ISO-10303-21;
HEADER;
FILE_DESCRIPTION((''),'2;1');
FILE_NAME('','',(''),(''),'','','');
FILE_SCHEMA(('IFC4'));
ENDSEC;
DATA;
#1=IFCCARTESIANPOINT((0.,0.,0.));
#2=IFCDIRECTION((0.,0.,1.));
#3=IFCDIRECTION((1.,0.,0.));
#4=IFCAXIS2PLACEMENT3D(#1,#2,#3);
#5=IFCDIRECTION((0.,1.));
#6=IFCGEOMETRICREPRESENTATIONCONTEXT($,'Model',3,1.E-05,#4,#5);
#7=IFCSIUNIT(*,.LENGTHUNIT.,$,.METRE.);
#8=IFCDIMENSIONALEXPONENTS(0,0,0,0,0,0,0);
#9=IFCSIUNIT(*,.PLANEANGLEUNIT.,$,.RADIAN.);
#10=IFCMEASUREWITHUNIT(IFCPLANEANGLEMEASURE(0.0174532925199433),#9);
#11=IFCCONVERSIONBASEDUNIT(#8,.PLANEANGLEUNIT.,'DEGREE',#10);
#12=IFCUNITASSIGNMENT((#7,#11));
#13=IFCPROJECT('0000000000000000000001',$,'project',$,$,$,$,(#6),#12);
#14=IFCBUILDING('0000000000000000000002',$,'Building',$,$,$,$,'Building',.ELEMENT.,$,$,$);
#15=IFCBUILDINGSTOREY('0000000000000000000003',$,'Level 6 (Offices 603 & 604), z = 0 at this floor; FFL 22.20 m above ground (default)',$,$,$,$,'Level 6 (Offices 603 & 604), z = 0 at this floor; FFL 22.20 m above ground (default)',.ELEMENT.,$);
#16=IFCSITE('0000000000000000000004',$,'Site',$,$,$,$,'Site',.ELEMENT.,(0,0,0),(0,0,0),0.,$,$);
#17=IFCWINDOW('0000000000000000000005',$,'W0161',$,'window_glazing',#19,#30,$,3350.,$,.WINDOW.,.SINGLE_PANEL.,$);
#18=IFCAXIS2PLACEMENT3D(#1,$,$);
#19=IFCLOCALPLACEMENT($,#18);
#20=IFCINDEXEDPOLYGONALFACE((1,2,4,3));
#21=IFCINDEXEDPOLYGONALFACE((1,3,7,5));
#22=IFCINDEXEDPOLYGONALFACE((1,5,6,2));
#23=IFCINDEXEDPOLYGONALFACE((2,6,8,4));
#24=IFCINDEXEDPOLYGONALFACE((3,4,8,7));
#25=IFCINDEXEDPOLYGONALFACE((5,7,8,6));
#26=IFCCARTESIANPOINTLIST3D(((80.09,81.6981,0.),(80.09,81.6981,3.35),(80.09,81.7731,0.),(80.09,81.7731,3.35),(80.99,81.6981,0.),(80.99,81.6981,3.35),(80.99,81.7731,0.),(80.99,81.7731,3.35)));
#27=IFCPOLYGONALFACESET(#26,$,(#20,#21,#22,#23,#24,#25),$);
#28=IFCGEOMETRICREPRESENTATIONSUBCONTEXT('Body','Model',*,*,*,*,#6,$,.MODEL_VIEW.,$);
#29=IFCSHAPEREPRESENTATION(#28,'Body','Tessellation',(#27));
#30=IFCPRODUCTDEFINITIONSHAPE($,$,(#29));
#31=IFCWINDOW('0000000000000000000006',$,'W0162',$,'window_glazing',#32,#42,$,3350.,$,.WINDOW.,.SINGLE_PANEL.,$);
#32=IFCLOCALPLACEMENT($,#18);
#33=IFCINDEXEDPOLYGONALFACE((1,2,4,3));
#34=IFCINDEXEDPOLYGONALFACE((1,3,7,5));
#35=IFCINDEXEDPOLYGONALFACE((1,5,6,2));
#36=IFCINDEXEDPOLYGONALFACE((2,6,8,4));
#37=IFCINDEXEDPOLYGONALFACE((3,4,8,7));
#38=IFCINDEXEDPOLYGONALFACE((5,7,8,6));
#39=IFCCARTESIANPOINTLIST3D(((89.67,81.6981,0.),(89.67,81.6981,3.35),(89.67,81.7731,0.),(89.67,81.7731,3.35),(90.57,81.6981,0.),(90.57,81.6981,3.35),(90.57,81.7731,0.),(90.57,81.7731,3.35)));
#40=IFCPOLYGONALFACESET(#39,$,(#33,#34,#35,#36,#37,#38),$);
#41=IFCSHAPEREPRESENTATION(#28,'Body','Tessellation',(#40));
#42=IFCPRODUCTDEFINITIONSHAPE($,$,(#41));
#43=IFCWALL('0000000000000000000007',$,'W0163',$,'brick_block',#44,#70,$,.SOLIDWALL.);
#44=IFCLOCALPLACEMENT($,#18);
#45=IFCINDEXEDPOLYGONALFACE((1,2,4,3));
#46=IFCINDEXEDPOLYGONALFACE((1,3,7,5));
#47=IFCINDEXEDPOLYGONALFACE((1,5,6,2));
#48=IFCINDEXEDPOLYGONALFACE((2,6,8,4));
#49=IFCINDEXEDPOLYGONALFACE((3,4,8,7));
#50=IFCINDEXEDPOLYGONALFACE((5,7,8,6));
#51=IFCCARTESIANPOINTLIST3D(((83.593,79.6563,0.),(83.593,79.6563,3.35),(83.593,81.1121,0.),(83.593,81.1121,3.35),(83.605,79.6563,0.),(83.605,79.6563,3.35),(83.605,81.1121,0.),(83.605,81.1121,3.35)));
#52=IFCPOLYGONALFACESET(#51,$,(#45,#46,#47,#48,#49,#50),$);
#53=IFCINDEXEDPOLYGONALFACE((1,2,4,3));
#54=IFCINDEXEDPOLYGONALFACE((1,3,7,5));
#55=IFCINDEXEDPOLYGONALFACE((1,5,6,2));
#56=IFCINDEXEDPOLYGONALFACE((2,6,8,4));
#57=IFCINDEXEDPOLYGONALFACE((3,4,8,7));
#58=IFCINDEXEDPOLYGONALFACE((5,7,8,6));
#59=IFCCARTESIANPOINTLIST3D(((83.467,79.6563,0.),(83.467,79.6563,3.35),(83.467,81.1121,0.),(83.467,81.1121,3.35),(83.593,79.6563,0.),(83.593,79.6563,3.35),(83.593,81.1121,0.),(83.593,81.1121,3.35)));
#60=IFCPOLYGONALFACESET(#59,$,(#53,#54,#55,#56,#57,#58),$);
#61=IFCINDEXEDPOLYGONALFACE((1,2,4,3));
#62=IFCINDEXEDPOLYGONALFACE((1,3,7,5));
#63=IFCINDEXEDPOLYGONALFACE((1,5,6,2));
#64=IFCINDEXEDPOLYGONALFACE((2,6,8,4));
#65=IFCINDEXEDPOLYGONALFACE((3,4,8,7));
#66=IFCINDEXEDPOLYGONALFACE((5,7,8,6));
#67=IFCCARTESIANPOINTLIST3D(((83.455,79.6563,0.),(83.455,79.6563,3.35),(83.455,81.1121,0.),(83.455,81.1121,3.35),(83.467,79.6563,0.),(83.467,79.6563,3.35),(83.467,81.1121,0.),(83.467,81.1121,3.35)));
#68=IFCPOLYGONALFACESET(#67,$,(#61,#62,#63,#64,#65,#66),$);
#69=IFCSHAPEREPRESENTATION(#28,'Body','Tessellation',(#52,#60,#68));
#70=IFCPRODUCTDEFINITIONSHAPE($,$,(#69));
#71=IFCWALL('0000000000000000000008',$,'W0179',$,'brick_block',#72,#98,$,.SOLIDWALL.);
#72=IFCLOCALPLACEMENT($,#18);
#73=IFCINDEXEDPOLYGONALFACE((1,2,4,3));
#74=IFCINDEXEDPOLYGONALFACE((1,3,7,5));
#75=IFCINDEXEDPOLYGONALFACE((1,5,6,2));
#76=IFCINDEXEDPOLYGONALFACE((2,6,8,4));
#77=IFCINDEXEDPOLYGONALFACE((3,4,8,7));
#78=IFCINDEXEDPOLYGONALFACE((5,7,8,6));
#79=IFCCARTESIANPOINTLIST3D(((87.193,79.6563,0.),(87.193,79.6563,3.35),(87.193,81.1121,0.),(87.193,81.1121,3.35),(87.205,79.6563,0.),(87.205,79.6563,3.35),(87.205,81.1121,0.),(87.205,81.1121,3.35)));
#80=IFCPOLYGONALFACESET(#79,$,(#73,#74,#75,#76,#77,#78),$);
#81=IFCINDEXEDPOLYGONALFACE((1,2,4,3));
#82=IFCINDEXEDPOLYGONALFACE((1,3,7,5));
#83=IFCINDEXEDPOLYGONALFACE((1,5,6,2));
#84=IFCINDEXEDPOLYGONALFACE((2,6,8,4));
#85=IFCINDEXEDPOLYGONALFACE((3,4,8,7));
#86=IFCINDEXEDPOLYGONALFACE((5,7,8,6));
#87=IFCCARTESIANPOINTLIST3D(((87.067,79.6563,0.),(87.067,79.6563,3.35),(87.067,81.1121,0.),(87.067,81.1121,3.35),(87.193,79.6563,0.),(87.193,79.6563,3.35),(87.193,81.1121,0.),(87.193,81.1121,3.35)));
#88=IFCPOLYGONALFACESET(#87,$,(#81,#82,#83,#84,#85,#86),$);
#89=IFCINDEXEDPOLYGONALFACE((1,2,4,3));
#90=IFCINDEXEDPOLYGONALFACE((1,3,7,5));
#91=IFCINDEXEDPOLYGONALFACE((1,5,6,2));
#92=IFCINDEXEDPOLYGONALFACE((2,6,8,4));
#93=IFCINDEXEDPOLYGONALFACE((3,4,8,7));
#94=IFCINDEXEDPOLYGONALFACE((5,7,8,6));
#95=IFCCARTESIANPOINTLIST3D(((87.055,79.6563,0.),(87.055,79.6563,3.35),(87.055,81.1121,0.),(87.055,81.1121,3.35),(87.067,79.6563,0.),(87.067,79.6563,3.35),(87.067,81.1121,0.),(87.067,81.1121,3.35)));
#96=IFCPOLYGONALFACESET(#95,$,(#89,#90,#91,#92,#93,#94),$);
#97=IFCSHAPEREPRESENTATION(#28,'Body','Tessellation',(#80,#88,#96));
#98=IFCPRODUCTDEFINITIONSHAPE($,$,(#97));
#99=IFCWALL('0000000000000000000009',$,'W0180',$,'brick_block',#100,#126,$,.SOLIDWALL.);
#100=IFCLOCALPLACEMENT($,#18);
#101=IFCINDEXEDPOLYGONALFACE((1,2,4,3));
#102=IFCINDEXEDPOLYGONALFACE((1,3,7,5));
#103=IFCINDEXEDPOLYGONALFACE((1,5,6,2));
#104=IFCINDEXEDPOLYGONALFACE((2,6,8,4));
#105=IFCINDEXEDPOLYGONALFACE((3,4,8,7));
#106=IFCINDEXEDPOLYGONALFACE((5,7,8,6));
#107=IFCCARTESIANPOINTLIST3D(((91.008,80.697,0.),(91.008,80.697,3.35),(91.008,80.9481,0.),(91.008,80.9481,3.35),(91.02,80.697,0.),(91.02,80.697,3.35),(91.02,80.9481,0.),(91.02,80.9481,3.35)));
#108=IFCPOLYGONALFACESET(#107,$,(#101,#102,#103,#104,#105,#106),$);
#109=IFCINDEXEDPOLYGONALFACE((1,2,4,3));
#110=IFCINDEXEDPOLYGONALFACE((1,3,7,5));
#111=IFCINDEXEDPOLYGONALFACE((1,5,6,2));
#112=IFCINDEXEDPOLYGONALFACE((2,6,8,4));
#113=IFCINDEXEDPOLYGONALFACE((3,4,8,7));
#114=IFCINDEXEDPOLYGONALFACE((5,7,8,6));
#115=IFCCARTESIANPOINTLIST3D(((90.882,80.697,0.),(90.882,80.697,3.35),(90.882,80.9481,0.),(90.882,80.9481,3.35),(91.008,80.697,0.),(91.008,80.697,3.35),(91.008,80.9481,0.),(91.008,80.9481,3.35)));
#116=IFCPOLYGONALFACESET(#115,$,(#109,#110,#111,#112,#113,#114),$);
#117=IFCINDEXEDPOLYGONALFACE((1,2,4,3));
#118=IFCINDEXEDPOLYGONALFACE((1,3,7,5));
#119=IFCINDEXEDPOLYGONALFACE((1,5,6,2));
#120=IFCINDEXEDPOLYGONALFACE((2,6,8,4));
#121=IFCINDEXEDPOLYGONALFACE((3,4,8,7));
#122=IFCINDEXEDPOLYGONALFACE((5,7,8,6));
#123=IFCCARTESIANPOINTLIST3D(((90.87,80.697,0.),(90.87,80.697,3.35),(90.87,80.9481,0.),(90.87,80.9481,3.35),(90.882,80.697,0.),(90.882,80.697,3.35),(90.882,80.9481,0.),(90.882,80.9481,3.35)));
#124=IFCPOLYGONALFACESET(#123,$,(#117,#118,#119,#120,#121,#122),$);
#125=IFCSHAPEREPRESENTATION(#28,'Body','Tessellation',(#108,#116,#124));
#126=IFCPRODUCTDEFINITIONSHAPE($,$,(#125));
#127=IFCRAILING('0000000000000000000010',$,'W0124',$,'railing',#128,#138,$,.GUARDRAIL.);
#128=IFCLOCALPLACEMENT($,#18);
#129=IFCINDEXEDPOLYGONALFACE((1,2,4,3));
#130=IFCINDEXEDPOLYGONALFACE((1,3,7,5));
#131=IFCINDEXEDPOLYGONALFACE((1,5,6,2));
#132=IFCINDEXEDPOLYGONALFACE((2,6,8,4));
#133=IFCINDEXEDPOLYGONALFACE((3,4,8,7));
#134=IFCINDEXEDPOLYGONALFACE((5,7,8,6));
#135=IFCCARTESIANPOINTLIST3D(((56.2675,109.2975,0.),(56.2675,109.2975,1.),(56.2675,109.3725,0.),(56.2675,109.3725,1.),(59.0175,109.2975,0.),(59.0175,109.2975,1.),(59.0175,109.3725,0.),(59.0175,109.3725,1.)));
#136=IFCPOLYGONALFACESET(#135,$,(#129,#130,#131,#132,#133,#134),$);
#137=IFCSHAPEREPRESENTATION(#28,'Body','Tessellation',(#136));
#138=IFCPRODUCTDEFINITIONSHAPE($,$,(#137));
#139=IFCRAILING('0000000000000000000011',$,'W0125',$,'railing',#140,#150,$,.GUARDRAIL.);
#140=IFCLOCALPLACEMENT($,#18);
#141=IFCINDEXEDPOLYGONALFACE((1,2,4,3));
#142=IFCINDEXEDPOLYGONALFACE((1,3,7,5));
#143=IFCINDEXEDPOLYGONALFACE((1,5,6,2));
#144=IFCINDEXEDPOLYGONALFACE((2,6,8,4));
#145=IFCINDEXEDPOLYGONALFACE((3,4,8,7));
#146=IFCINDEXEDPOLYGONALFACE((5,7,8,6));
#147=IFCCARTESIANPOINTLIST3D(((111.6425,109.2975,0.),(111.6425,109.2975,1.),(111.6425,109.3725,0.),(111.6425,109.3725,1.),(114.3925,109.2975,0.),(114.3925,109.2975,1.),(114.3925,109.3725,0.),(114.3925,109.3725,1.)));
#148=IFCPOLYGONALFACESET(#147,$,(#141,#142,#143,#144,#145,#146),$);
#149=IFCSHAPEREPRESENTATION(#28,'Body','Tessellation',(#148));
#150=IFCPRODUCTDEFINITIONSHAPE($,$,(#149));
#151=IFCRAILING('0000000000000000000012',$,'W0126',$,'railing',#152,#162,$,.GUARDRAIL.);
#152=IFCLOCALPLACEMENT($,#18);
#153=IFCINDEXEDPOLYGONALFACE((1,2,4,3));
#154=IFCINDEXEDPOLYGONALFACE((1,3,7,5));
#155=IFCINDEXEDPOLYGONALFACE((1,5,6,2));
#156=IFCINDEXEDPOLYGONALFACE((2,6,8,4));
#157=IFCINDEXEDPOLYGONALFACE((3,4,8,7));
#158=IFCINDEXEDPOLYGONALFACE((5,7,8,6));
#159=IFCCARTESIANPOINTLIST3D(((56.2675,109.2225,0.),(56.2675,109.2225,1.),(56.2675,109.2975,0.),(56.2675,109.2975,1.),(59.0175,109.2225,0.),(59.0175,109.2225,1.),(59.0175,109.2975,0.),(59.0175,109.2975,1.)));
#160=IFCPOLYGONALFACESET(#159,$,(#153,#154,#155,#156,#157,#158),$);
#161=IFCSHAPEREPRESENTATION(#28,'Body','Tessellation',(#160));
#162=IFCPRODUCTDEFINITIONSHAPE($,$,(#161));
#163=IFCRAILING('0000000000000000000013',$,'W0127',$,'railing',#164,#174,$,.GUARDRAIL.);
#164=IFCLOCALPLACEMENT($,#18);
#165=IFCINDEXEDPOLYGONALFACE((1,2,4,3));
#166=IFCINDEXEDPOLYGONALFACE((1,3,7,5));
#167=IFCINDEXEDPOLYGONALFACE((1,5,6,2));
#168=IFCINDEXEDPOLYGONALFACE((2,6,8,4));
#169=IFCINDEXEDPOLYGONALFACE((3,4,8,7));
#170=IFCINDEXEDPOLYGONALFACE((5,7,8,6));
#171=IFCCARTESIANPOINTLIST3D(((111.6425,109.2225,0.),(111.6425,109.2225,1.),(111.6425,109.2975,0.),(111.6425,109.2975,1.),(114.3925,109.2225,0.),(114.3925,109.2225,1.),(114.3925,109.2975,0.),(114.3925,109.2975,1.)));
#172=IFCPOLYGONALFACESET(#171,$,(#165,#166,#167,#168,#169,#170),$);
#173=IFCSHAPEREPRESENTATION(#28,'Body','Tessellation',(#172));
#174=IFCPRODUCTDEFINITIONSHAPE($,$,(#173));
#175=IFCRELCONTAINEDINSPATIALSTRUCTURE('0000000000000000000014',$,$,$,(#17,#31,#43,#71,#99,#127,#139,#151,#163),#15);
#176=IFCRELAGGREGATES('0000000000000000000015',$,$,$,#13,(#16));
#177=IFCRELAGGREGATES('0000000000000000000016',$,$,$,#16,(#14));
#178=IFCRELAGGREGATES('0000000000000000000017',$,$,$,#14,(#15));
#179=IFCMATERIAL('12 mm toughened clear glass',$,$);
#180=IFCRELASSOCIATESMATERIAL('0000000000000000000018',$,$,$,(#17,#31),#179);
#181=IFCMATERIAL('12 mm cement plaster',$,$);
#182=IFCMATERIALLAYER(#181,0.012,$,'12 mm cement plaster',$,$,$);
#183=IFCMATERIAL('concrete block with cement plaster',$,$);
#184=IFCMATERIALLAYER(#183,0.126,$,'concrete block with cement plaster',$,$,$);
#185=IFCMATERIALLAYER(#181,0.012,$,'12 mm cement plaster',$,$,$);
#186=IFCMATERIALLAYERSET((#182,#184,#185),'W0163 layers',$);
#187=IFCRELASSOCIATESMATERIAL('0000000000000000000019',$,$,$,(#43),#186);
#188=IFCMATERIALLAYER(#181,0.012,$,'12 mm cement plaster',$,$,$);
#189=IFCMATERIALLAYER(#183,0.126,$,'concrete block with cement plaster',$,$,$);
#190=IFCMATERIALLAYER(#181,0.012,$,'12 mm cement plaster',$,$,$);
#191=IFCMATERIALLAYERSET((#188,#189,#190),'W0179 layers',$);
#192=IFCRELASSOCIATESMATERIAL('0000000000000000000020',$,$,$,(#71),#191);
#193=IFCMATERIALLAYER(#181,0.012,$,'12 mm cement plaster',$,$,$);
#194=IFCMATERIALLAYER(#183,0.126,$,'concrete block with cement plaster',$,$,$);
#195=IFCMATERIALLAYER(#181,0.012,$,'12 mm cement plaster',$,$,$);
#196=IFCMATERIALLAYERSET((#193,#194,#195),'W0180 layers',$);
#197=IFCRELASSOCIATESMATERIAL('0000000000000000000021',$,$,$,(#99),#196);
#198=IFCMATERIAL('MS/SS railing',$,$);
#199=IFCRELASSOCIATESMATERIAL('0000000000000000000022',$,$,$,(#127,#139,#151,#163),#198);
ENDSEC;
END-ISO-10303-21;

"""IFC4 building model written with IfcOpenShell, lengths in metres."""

from ifc_helpers import new_model, entity, si_unit, converted_unit, direction, frame, frame_2d, origin_with_axes, place, context, subcontext, project, spatial, rectangle, extrude, material, layer, layer_set, layer_usage, element, save


model = new_model("IFC4")

# Units and contexts
model_context = context("Model", 3, precision=1e-05, world=origin_with_axes(), true_north=direction((0.0, 1.0)))
body_context = subcontext(model_context, "Body", "Model", "MODEL_VIEW")
ifc_project = project(units=[si_unit("LENGTHUNIT", "METRE"), converted_unit("PLANEANGLEUNIT", "DEGREE", entity("IfcPlaneAngleMeasure", 0.0174532925199433), si_unit("PLANEANGLEUNIT", "RADIAN"), dimensions=[0, 0, 0, 0, 0, 0, 0])], contexts=[model_context])

# Site, building, storey
site = spatial("IfcSite", under=ifc_project, Name="Site", LongName="Site", CompositionType="ELEMENT", RefLatitude=(0, 0, 0), RefLongitude=(0, 0, 0), RefElevation=0.0)
building = spatial("IfcBuilding", under=site, Name="Building", LongName="Building", CompositionType="ELEMENT")
storey = spatial("IfcBuildingStorey", under=building, Name="Level 6 (Offices 603 & 604), z = 0 at this floor; FFL 22.20 m above ground (default)", LongName="Level 6 (Offices 603 & 604), z = 0 at this floor; FFL 22.20 m above ground (default)", CompositionType="ELEMENT")

# Shared definitions
ifc_material_1 = material(Name="12 mm cement plaster")
ifc_material_2 = material(Name="concrete block with cement plaster")
placement = place(None, origin_with_axes())

# Shared definitions
ifc_material_3 = material(Name="12 mm toughened clear glass")

# Windows
element("IfcWindow", 1, at=placement, inside=storey, material=ifc_material_3, Name="W0161", ObjectType="window_glazing", OverallHeight=3350.0, PartitioningType="SINGLE_PANEL", PredefinedType="WINDOW", context=body_context, shape_type="SweptSolid", body=[
    extrude(rectangle(XDim=0.9, YDim=0.075, at=frame_2d((0.0, 0.0), x_axis=(1.0, 0.0))), frame((80.54, 81.7356, 0.0), z_axis=(0.0, 0.0, 1.0), x_axis=(1.0, 0.0, 0.0)), (0.0, 0.0, 1.0), 3.35),
])
element("IfcWindow", 2, at=placement, inside=storey, material=ifc_material_3, Name="W0162", ObjectType="window_glazing", OverallHeight=3350.0, PartitioningType="SINGLE_PANEL", PredefinedType="WINDOW", context=body_context, shape_type="SweptSolid", body=[
    extrude(rectangle(XDim=0.9, YDim=0.075, at=frame_2d((0.0, 0.0), x_axis=(1.0, 0.0))), frame((90.12, 81.7356, 0.0), z_axis=(0.0, 0.0, 1.0), x_axis=(1.0, 0.0, 0.0)), (0.0, 0.0, 1.0), 3.35),
])

# Walls
ifc_layer_1 = layer(ifc_material_1, 0.012, Name="12 mm cement plaster")
ifc_layer_2 = layer(ifc_material_2, 0.126, Name="concrete block with cement plaster")
ifc_layer_3 = layer(ifc_material_1, 0.012, Name="12 mm cement plaster")
ifc_layer_set_1 = layer_set([ifc_layer_1, ifc_layer_2, ifc_layer_3], Name="W0163 layers")
ifc_layer_usage_1 = layer_usage(ifc_layer_set_1, "AXIS2", "POSITIVE", -0.075)
element("IfcWall", 3, at=placement, inside=storey, material=ifc_layer_usage_1, Name="W0163", ObjectType="brick_block", PredefinedType="SOLIDWALL", context=body_context, shape_type="SweptSolid", body=[
    extrude(rectangle(XDim=1.4558, YDim=0.012, at=frame_2d((0.0, 0.0), x_axis=(0.0, 1.0))), frame((83.599, 80.3842, 0.0), z_axis=(0.0, 0.0, 1.0), x_axis=(1.0, 0.0, 0.0)), (0.0, 0.0, 1.0), 3.35),
    extrude(rectangle(XDim=1.4558, YDim=0.126, at=frame_2d((-0.069, 0.0), x_axis=(0.0, 1.0))), frame((83.599, 80.3842, 0.0), z_axis=(0.0, 0.0, 1.0), x_axis=(1.0, 0.0, 0.0)), (0.0, 0.0, 1.0), 3.35),
    extrude(rectangle(XDim=1.4558, YDim=0.012, at=frame_2d((-0.138, 0.0), x_axis=(0.0, 1.0))), frame((83.599, 80.3842, 0.0), z_axis=(0.0, 0.0, 1.0), x_axis=(1.0, 0.0, 0.0)), (0.0, 0.0, 1.0), 3.35),
])
ifc_layer_4 = layer(ifc_material_1, 0.012, Name="12 mm cement plaster")
ifc_layer_5 = layer(ifc_material_2, 0.126, Name="concrete block with cement plaster")
ifc_layer_6 = layer(ifc_material_1, 0.012, Name="12 mm cement plaster")
ifc_layer_set_2 = layer_set([ifc_layer_4, ifc_layer_5, ifc_layer_6], Name="W0179 layers")
ifc_layer_usage_2 = layer_usage(ifc_layer_set_2, "AXIS2", "POSITIVE", -0.075)
element("IfcWall", 4, at=placement, inside=storey, material=ifc_layer_usage_2, Name="W0179", ObjectType="brick_block", PredefinedType="SOLIDWALL", context=body_context, shape_type="SweptSolid", body=[
    extrude(rectangle(XDim=1.4558, YDim=0.012, at=frame_2d((0.0, 0.0), x_axis=(0.0, 1.0))), frame((87.199, 80.3842, 0.0), z_axis=(0.0, 0.0, 1.0), x_axis=(1.0, 0.0, 0.0)), (0.0, 0.0, 1.0), 3.35),
    extrude(rectangle(XDim=1.4558, YDim=0.126, at=frame_2d((-0.069, 0.0), x_axis=(0.0, 1.0))), frame((87.199, 80.3842, 0.0), z_axis=(0.0, 0.0, 1.0), x_axis=(1.0, 0.0, 0.0)), (0.0, 0.0, 1.0), 3.35),
    extrude(rectangle(XDim=1.4558, YDim=0.012, at=frame_2d((-0.138, 0.0), x_axis=(0.0, 1.0))), frame((87.199, 80.3842, 0.0), z_axis=(0.0, 0.0, 1.0), x_axis=(1.0, 0.0, 0.0)), (0.0, 0.0, 1.0), 3.35),
])
ifc_layer_7 = layer(ifc_material_1, 0.012, Name="12 mm cement plaster")
ifc_layer_8 = layer(ifc_material_2, 0.126, Name="concrete block with cement plaster")
ifc_layer_9 = layer(ifc_material_1, 0.012, Name="12 mm cement plaster")
ifc_layer_set_3 = layer_set([ifc_layer_7, ifc_layer_8, ifc_layer_9], Name="W0180 layers")
ifc_layer_usage_3 = layer_usage(ifc_layer_set_3, "AXIS2", "POSITIVE", -0.075)
element("IfcWall", 5, at=placement, inside=storey, material=ifc_layer_usage_3, Name="W0180", ObjectType="brick_block", PredefinedType="SOLIDWALL", context=body_context, shape_type="SweptSolid", body=[
    extrude(rectangle(XDim=0.2511, YDim=0.012, at=frame_2d((0.0, 0.0), x_axis=(0.0, 1.0))), frame((91.014, 80.8226, 0.0), z_axis=(0.0, 0.0, 1.0), x_axis=(1.0, 0.0, 0.0)), (0.0, 0.0, 1.0), 3.35),
    extrude(rectangle(XDim=0.2511, YDim=0.126, at=frame_2d((-0.069, 0.0), x_axis=(0.0, 1.0))), frame((91.014, 80.8226, 0.0), z_axis=(0.0, 0.0, 1.0), x_axis=(1.0, 0.0, 0.0)), (0.0, 0.0, 1.0), 3.35),
    extrude(rectangle(XDim=0.2511, YDim=0.012, at=frame_2d((-0.138, 0.0), x_axis=(0.0, 1.0))), frame((91.014, 80.8226, 0.0), z_axis=(0.0, 0.0, 1.0), x_axis=(1.0, 0.0, 0.0)), (0.0, 0.0, 1.0), 3.35),
])

# Railings
ifc_material_4 = material(Name="MS/SS railing")
element("IfcRailing", 6, at=placement, inside=storey, material=ifc_material_4, Name="W0124", ObjectType="railing", PredefinedType="GUARDRAIL", context=body_context, shape_type="SweptSolid", body=[
    extrude(rectangle(XDim=2.75, YDim=0.075, at=frame_2d((0.0, 0.0), x_axis=(1.0, 0.0))), frame((57.6425, 109.335, 0.0), z_axis=(0.0, 0.0, 1.0), x_axis=(1.0, 0.0, 0.0)), (0.0, 0.0, 1.0), 1.0),
])
element("IfcRailing", 7, at=placement, inside=storey, material=ifc_material_4, Name="W0125", ObjectType="railing", PredefinedType="GUARDRAIL", context=body_context, shape_type="SweptSolid", body=[
    extrude(rectangle(XDim=2.75, YDim=0.075, at=frame_2d((0.0, 0.0), x_axis=(1.0, 0.0))), frame((113.0175, 109.335, 0.0), z_axis=(0.0, 0.0, 1.0), x_axis=(1.0, 0.0, 0.0)), (0.0, 0.0, 1.0), 1.0),
])
element("IfcRailing", 8, at=placement, inside=storey, material=ifc_material_4, Name="W0126", ObjectType="railing", PredefinedType="GUARDRAIL", context=body_context, shape_type="SweptSolid", body=[
    extrude(rectangle(XDim=2.75, YDim=0.075, at=frame_2d((0.0, 0.0), x_axis=(1.0, 0.0))), frame((57.6425, 109.26, 0.0), z_axis=(0.0, 0.0, 1.0), x_axis=(1.0, 0.0, 0.0)), (0.0, 0.0, 1.0), 1.0),
])
element("IfcRailing", 9, at=placement, inside=storey, material=ifc_material_4, Name="W0127", ObjectType="railing", PredefinedType="GUARDRAIL", context=body_context, shape_type="SweptSolid", body=[
    extrude(rectangle(XDim=2.75, YDim=0.075, at=frame_2d((0.0, 0.0), x_axis=(1.0, 0.0))), frame((113.0175, 109.26, 0.0), z_axis=(0.0, 0.0, 1.0), x_axis=(1.0, 0.0, 0.0)), (0.0, 0.0, 1.0), 1.0),
])

save(model, "model.ifc")
